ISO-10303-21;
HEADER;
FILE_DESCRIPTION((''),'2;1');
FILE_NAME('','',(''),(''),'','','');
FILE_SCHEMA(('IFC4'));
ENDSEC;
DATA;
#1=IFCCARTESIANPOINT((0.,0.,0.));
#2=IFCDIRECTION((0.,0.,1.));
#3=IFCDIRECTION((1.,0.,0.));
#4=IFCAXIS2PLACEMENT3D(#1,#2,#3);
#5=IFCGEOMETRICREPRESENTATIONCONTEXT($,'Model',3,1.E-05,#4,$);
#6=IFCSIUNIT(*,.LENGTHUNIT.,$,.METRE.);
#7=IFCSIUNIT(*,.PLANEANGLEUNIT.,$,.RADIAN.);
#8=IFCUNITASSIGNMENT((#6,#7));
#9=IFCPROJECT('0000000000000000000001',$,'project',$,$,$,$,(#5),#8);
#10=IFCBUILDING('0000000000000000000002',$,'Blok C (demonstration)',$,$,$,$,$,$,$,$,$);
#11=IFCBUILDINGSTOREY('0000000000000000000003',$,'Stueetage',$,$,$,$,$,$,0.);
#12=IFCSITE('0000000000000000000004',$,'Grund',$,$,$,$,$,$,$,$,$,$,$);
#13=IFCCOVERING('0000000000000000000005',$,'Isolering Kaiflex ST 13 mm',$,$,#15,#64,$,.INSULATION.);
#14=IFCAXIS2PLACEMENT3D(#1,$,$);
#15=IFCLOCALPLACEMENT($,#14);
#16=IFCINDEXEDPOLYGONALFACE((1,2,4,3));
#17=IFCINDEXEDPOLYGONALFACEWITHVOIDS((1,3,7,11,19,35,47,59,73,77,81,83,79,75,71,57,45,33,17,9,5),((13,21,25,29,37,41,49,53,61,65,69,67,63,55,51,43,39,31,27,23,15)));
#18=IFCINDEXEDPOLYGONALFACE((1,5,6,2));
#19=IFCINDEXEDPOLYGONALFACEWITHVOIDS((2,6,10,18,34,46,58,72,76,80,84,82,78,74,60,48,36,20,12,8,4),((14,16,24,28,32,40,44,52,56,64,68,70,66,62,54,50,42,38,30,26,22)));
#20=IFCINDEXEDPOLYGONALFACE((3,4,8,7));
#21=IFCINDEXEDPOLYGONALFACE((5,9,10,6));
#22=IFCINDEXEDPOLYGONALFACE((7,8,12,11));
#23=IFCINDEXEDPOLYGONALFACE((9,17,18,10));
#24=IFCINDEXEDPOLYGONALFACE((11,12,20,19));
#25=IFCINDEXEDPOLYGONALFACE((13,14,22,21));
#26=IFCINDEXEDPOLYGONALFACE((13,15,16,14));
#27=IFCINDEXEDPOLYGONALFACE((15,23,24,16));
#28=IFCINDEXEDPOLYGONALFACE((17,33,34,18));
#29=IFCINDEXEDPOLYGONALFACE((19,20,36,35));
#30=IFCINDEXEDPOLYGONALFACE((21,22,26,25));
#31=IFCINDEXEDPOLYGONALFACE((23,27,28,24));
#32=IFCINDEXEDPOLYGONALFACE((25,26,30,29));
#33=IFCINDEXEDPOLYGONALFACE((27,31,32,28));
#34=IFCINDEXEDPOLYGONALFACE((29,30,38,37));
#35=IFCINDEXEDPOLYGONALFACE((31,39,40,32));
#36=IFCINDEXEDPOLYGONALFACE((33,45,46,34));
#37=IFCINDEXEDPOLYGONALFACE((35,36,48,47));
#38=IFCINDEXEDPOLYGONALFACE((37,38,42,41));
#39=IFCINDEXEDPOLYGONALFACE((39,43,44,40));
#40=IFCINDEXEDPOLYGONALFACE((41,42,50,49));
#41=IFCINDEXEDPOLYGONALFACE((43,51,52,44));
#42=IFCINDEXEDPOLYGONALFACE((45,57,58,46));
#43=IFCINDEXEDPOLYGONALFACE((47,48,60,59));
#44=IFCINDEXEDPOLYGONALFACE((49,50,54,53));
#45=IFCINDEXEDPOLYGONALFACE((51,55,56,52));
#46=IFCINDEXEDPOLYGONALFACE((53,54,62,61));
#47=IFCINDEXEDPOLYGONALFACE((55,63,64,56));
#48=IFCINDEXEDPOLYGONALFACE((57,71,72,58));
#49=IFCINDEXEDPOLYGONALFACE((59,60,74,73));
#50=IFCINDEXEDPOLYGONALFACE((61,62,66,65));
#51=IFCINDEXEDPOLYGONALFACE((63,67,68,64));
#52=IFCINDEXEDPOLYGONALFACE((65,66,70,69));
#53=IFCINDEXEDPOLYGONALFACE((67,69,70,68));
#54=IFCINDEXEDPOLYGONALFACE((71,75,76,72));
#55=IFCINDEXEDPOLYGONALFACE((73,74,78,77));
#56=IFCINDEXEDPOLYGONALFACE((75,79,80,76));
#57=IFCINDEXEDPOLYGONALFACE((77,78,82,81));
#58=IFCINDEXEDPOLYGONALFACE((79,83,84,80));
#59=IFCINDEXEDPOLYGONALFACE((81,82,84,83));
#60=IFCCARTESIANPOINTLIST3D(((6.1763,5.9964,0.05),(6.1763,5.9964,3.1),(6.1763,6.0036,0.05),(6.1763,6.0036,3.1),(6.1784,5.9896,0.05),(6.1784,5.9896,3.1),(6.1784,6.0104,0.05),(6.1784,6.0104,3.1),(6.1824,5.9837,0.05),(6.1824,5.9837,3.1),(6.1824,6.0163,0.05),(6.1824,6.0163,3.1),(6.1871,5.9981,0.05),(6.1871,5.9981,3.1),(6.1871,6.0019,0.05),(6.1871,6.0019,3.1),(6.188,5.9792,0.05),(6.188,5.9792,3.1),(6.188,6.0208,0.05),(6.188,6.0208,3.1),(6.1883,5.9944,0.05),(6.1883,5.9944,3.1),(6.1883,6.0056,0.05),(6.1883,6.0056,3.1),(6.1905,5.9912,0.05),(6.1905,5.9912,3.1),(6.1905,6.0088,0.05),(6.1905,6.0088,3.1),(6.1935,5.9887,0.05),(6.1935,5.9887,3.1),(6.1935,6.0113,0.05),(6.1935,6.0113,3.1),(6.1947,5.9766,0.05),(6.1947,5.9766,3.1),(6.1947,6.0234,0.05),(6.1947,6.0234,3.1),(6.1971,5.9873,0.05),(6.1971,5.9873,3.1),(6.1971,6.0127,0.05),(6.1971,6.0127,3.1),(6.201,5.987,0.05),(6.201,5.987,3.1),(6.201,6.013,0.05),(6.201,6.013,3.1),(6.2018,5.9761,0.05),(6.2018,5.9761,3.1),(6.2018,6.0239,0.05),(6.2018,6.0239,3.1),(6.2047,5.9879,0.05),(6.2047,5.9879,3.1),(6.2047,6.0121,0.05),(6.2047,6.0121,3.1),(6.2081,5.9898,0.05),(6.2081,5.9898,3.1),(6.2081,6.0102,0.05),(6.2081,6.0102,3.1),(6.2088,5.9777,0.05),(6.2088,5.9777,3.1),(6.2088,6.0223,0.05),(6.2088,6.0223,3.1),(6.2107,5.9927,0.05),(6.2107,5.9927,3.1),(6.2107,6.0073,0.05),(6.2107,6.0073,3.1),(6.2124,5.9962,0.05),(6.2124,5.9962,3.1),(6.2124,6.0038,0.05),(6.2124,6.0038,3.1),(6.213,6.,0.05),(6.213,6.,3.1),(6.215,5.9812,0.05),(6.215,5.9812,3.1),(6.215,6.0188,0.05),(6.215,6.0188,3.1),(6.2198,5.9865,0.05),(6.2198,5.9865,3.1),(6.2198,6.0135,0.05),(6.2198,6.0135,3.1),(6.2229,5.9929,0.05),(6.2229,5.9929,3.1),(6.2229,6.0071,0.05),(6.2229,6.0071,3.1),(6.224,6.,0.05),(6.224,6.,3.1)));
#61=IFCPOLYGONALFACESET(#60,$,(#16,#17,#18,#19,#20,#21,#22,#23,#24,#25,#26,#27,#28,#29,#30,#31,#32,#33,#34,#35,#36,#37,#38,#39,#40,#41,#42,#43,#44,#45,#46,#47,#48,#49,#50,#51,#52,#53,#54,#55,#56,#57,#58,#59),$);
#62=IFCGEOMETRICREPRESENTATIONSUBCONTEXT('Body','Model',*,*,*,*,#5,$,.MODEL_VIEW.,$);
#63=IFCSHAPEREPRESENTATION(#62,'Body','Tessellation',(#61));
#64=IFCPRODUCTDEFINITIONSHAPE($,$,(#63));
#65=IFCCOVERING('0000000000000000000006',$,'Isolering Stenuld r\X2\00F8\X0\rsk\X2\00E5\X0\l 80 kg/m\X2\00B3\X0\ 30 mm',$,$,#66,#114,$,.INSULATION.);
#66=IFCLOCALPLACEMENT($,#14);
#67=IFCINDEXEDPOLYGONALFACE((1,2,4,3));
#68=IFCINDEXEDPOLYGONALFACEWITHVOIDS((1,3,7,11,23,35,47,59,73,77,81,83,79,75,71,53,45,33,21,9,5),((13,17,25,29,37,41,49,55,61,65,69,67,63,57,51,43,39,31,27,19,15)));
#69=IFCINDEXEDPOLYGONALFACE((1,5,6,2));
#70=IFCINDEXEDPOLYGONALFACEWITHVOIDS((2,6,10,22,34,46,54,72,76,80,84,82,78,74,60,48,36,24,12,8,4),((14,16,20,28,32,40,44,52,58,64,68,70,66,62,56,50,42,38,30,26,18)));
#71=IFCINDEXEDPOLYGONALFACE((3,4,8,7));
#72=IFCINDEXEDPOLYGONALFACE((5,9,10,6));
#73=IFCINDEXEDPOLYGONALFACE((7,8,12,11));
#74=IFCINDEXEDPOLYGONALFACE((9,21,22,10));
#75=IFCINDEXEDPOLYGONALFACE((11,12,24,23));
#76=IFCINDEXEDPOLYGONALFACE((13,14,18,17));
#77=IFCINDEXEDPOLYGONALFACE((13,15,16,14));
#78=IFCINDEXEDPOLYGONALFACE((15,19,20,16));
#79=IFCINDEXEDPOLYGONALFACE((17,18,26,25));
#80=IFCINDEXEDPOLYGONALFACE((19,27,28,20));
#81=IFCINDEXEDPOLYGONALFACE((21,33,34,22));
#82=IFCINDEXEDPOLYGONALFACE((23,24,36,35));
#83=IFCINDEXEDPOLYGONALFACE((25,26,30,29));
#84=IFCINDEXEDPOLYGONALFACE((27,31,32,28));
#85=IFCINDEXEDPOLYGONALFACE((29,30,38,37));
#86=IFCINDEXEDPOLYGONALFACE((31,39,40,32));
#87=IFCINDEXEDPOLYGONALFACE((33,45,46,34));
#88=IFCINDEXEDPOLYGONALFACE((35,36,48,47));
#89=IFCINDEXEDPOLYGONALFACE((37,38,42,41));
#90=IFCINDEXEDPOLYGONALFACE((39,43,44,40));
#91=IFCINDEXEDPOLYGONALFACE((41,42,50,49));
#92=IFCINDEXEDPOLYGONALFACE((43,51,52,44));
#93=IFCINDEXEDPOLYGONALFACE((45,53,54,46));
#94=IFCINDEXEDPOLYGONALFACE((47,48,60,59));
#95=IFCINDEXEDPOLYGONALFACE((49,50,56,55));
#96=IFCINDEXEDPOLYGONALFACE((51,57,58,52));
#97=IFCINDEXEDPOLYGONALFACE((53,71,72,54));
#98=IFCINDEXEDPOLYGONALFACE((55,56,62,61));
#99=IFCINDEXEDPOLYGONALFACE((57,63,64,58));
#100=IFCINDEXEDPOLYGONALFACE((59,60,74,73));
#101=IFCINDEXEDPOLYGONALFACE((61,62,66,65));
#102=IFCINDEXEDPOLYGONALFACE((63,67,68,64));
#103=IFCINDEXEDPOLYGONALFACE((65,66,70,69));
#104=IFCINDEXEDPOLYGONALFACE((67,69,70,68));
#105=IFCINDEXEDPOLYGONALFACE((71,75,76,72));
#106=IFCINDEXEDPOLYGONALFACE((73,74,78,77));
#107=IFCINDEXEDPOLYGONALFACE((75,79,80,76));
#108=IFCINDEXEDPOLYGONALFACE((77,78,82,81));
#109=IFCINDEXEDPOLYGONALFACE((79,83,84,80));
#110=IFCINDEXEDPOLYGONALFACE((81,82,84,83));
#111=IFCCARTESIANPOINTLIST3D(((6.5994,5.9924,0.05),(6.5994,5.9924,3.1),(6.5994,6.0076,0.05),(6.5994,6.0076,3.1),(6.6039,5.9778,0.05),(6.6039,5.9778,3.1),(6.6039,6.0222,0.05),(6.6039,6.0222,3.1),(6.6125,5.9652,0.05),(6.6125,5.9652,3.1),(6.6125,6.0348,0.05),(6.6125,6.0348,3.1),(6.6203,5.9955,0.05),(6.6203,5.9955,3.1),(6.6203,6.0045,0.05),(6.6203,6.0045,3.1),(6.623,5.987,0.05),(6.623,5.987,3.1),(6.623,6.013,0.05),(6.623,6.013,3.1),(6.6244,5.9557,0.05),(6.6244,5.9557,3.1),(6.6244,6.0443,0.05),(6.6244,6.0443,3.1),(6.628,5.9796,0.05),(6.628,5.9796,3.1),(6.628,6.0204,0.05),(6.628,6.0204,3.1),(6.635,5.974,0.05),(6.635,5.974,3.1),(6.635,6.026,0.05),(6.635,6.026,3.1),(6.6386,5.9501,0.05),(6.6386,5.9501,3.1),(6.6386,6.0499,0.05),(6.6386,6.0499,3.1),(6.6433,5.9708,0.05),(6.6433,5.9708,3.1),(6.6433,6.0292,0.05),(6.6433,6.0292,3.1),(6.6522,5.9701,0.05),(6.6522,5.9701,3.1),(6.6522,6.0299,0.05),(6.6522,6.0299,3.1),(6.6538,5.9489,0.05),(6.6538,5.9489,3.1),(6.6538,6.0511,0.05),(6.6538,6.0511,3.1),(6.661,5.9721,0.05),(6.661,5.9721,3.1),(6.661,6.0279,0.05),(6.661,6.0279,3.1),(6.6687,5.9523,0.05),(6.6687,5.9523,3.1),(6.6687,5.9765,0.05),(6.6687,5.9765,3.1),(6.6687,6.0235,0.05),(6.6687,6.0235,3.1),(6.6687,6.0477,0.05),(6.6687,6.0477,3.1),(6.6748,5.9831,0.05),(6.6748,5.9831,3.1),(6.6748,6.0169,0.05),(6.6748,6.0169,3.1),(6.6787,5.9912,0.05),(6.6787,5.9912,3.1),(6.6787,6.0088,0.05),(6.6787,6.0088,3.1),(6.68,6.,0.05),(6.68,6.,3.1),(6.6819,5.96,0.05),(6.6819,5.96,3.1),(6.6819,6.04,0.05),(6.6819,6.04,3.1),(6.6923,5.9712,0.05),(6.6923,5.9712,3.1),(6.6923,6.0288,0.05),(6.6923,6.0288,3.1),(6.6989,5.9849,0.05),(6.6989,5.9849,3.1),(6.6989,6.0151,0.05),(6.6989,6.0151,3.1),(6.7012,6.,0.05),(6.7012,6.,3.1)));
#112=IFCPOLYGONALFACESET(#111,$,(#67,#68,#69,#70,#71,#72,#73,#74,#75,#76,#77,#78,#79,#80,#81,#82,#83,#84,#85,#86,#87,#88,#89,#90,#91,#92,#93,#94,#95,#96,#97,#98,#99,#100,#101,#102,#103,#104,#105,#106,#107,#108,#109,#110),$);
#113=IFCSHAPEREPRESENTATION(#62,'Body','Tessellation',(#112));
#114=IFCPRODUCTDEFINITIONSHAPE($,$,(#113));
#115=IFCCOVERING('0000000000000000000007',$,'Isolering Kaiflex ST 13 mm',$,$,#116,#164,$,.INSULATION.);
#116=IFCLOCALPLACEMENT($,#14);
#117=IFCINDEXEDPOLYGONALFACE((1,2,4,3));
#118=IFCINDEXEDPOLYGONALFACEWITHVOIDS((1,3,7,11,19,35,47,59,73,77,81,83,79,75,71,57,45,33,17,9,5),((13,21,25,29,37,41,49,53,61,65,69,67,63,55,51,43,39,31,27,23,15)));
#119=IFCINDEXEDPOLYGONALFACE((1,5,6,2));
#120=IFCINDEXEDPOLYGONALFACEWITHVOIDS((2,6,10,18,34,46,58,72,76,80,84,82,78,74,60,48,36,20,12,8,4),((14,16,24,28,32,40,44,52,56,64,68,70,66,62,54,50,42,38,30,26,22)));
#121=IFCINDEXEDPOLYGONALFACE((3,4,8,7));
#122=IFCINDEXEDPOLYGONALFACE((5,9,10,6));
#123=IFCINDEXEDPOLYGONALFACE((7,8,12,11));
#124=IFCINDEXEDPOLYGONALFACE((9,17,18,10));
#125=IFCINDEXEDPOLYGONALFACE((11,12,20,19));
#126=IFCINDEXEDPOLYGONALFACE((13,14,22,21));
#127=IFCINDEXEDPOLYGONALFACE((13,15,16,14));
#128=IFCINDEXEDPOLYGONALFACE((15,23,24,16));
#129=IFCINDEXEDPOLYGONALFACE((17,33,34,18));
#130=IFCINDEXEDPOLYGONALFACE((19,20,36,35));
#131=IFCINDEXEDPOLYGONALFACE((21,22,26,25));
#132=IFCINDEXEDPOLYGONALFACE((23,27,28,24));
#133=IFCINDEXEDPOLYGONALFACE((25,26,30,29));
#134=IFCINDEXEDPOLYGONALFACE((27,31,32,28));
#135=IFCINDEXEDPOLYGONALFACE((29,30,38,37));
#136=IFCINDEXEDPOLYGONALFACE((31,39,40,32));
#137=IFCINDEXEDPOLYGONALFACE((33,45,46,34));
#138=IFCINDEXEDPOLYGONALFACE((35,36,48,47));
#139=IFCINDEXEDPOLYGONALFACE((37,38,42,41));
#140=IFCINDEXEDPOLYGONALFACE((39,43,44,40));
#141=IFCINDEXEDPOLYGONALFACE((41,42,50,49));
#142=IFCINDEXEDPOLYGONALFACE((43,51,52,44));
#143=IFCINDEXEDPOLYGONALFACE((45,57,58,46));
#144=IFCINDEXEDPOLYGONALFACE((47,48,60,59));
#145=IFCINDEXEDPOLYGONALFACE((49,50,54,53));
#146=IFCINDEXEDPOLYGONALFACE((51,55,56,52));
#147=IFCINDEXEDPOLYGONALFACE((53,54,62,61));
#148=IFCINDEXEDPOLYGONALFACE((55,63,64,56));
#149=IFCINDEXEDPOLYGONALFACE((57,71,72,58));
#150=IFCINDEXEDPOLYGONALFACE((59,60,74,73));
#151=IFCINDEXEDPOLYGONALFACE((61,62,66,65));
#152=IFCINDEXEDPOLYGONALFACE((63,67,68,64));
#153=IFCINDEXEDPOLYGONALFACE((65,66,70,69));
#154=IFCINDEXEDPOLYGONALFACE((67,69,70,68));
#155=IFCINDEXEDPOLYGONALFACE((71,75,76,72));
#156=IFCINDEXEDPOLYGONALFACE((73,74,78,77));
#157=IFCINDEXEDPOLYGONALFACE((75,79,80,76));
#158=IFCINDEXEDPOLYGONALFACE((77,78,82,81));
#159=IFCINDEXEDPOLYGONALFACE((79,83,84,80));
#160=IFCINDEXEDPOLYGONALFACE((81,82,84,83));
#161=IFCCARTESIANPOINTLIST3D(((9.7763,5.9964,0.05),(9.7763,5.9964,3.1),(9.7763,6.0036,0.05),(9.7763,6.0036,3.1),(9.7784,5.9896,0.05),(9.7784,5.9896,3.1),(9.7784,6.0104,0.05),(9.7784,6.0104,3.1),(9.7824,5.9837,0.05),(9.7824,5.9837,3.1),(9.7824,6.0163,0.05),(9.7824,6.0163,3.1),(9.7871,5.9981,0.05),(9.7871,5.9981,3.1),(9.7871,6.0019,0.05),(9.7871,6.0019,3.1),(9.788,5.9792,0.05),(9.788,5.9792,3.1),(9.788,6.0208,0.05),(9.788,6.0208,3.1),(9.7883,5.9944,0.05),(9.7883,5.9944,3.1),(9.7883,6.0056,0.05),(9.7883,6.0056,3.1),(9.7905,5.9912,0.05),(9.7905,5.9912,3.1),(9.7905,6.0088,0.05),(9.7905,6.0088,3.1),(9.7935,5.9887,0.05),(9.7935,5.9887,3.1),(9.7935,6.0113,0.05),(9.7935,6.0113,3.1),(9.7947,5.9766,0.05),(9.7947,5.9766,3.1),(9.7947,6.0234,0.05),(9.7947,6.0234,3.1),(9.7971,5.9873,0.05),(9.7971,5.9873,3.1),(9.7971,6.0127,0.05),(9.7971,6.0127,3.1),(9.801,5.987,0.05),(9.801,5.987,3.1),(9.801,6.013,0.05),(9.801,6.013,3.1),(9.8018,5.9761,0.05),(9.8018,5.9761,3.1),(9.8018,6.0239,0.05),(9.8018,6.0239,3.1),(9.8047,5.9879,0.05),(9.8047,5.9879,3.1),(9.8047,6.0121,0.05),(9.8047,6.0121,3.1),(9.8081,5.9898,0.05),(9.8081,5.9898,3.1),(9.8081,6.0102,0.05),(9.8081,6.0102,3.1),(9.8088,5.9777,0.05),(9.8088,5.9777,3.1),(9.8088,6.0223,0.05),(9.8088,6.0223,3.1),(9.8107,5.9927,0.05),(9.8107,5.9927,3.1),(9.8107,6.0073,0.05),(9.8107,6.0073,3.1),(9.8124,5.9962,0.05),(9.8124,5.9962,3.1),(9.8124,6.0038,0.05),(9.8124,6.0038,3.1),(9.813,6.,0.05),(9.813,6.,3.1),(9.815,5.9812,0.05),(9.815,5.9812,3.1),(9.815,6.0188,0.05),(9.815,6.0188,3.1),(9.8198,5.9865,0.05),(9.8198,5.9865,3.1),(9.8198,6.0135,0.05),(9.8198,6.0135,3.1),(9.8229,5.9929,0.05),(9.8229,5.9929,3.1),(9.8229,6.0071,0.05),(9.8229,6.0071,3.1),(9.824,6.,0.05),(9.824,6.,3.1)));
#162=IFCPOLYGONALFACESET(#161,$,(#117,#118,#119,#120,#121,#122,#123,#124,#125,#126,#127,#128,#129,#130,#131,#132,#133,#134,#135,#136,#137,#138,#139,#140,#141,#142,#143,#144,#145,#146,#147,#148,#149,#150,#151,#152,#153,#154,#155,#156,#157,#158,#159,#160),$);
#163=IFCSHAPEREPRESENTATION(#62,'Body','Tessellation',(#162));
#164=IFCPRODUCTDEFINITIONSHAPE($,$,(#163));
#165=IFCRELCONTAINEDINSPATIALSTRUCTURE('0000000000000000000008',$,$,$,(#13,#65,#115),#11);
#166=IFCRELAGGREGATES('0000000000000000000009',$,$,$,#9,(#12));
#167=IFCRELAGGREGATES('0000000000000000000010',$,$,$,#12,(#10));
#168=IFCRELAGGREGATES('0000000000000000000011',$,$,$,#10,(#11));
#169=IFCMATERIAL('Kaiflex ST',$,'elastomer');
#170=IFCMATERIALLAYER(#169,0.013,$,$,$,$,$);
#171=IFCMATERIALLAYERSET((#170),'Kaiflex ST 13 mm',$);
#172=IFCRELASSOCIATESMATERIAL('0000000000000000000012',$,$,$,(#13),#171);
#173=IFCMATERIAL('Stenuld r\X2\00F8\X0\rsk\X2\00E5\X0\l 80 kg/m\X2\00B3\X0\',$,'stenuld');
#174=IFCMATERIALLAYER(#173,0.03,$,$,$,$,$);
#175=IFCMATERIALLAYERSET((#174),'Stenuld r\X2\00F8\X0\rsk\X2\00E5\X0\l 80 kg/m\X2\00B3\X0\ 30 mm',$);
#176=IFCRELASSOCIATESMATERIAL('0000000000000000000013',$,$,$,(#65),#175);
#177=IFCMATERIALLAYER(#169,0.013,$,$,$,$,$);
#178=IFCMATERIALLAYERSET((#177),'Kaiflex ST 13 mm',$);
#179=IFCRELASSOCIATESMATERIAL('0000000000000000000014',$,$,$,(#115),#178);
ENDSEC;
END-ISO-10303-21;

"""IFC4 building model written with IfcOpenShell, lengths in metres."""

from ifc_helpers import new_model, si_unit, frame, origin_with_axes, place, context, subcontext, project, spatial, hollow_circle, extrude, material, layer, layer_set, element, save


model = new_model("IFC4")

# Units and contexts
model_context = context("Model", 3, precision=1e-05, world=origin_with_axes())
body_context = subcontext(model_context, "Body", "Model", "MODEL_VIEW")
ifc_project = project(units=[si_unit("LENGTHUNIT", "METRE"), si_unit("PLANEANGLEUNIT", "RADIAN")], contexts=[model_context])

# Site, building, storey
site = spatial("IfcSite", under=ifc_project, Name="Grund")
building = spatial("IfcBuilding", under=site, Name="Blok C (demonstration)")
storey = spatial("IfcBuildingStorey", under=building, Name="Stueetage", Elevation=0.0)

# Coverings
ifc_material_1 = material(Name="Kaiflex ST", Category="elastomer")
ifc_layer_1 = layer(ifc_material_1, 0.013)
ifc_layer_set_1 = layer_set([ifc_layer_1], Name="Kaiflex ST 13 mm")
covering_1_placement = place(None, origin_with_axes())
element("IfcCovering", 1, at=covering_1_placement, inside=storey, material=ifc_layer_set_1, Name="Isolering Kaiflex ST 13 mm", PredefinedType="INSULATION", context=body_context, shape_type="SweptSolid", body=[
    extrude(hollow_circle(Radius=0.024, WallThickness=0.011), frame((6.2, 6.0, 0.05), z_axis=(0.0, 0.0, 1.0), x_axis=(1.0, 0.0, 0.0)), (0.0, 0.0, 1.0), 3.05),
])
ifc_material_2 = material(Name="Stenuld rørskål 80 kg/m³", Category="stenuld")
ifc_layer_2 = layer(ifc_material_2, 0.03)
ifc_layer_set_2 = layer_set([ifc_layer_2], Name="Stenuld rørskål 80 kg/m³ 30 mm")
covering_2_placement = place(None, origin_with_axes())
element("IfcCovering", 2, at=covering_2_placement, inside=storey, material=ifc_layer_set_2, Name="Isolering Stenuld rørskål 80 kg/m³ 30 mm", PredefinedType="INSULATION", context=body_context, shape_type="SweptSolid", body=[
    extrude(hollow_circle(Radius=0.0512, WallThickness=0.0212), frame((6.65, 6.0, 0.05), z_axis=(0.0, 0.0, 1.0), x_axis=(1.0, 0.0, 0.0)), (0.0, 0.0, 1.0), 3.05),
])
ifc_layer_3 = layer(ifc_material_1, 0.013)
ifc_layer_set_3 = layer_set([ifc_layer_3], Name="Kaiflex ST 13 mm")
covering_3_placement = place(None, origin_with_axes())
element("IfcCovering", 3, at=covering_3_placement, inside=storey, material=ifc_layer_set_3, Name="Isolering Kaiflex ST 13 mm", PredefinedType="INSULATION", context=body_context, shape_type="SweptSolid", body=[
    extrude(hollow_circle(Radius=0.024, WallThickness=0.011), frame((9.8, 6.0, 0.05), z_axis=(0.0, 0.0, 1.0), x_axis=(1.0, 0.0, 0.0)), (0.0, 0.0, 1.0), 3.05),
])

save(model, "model.ifc")
